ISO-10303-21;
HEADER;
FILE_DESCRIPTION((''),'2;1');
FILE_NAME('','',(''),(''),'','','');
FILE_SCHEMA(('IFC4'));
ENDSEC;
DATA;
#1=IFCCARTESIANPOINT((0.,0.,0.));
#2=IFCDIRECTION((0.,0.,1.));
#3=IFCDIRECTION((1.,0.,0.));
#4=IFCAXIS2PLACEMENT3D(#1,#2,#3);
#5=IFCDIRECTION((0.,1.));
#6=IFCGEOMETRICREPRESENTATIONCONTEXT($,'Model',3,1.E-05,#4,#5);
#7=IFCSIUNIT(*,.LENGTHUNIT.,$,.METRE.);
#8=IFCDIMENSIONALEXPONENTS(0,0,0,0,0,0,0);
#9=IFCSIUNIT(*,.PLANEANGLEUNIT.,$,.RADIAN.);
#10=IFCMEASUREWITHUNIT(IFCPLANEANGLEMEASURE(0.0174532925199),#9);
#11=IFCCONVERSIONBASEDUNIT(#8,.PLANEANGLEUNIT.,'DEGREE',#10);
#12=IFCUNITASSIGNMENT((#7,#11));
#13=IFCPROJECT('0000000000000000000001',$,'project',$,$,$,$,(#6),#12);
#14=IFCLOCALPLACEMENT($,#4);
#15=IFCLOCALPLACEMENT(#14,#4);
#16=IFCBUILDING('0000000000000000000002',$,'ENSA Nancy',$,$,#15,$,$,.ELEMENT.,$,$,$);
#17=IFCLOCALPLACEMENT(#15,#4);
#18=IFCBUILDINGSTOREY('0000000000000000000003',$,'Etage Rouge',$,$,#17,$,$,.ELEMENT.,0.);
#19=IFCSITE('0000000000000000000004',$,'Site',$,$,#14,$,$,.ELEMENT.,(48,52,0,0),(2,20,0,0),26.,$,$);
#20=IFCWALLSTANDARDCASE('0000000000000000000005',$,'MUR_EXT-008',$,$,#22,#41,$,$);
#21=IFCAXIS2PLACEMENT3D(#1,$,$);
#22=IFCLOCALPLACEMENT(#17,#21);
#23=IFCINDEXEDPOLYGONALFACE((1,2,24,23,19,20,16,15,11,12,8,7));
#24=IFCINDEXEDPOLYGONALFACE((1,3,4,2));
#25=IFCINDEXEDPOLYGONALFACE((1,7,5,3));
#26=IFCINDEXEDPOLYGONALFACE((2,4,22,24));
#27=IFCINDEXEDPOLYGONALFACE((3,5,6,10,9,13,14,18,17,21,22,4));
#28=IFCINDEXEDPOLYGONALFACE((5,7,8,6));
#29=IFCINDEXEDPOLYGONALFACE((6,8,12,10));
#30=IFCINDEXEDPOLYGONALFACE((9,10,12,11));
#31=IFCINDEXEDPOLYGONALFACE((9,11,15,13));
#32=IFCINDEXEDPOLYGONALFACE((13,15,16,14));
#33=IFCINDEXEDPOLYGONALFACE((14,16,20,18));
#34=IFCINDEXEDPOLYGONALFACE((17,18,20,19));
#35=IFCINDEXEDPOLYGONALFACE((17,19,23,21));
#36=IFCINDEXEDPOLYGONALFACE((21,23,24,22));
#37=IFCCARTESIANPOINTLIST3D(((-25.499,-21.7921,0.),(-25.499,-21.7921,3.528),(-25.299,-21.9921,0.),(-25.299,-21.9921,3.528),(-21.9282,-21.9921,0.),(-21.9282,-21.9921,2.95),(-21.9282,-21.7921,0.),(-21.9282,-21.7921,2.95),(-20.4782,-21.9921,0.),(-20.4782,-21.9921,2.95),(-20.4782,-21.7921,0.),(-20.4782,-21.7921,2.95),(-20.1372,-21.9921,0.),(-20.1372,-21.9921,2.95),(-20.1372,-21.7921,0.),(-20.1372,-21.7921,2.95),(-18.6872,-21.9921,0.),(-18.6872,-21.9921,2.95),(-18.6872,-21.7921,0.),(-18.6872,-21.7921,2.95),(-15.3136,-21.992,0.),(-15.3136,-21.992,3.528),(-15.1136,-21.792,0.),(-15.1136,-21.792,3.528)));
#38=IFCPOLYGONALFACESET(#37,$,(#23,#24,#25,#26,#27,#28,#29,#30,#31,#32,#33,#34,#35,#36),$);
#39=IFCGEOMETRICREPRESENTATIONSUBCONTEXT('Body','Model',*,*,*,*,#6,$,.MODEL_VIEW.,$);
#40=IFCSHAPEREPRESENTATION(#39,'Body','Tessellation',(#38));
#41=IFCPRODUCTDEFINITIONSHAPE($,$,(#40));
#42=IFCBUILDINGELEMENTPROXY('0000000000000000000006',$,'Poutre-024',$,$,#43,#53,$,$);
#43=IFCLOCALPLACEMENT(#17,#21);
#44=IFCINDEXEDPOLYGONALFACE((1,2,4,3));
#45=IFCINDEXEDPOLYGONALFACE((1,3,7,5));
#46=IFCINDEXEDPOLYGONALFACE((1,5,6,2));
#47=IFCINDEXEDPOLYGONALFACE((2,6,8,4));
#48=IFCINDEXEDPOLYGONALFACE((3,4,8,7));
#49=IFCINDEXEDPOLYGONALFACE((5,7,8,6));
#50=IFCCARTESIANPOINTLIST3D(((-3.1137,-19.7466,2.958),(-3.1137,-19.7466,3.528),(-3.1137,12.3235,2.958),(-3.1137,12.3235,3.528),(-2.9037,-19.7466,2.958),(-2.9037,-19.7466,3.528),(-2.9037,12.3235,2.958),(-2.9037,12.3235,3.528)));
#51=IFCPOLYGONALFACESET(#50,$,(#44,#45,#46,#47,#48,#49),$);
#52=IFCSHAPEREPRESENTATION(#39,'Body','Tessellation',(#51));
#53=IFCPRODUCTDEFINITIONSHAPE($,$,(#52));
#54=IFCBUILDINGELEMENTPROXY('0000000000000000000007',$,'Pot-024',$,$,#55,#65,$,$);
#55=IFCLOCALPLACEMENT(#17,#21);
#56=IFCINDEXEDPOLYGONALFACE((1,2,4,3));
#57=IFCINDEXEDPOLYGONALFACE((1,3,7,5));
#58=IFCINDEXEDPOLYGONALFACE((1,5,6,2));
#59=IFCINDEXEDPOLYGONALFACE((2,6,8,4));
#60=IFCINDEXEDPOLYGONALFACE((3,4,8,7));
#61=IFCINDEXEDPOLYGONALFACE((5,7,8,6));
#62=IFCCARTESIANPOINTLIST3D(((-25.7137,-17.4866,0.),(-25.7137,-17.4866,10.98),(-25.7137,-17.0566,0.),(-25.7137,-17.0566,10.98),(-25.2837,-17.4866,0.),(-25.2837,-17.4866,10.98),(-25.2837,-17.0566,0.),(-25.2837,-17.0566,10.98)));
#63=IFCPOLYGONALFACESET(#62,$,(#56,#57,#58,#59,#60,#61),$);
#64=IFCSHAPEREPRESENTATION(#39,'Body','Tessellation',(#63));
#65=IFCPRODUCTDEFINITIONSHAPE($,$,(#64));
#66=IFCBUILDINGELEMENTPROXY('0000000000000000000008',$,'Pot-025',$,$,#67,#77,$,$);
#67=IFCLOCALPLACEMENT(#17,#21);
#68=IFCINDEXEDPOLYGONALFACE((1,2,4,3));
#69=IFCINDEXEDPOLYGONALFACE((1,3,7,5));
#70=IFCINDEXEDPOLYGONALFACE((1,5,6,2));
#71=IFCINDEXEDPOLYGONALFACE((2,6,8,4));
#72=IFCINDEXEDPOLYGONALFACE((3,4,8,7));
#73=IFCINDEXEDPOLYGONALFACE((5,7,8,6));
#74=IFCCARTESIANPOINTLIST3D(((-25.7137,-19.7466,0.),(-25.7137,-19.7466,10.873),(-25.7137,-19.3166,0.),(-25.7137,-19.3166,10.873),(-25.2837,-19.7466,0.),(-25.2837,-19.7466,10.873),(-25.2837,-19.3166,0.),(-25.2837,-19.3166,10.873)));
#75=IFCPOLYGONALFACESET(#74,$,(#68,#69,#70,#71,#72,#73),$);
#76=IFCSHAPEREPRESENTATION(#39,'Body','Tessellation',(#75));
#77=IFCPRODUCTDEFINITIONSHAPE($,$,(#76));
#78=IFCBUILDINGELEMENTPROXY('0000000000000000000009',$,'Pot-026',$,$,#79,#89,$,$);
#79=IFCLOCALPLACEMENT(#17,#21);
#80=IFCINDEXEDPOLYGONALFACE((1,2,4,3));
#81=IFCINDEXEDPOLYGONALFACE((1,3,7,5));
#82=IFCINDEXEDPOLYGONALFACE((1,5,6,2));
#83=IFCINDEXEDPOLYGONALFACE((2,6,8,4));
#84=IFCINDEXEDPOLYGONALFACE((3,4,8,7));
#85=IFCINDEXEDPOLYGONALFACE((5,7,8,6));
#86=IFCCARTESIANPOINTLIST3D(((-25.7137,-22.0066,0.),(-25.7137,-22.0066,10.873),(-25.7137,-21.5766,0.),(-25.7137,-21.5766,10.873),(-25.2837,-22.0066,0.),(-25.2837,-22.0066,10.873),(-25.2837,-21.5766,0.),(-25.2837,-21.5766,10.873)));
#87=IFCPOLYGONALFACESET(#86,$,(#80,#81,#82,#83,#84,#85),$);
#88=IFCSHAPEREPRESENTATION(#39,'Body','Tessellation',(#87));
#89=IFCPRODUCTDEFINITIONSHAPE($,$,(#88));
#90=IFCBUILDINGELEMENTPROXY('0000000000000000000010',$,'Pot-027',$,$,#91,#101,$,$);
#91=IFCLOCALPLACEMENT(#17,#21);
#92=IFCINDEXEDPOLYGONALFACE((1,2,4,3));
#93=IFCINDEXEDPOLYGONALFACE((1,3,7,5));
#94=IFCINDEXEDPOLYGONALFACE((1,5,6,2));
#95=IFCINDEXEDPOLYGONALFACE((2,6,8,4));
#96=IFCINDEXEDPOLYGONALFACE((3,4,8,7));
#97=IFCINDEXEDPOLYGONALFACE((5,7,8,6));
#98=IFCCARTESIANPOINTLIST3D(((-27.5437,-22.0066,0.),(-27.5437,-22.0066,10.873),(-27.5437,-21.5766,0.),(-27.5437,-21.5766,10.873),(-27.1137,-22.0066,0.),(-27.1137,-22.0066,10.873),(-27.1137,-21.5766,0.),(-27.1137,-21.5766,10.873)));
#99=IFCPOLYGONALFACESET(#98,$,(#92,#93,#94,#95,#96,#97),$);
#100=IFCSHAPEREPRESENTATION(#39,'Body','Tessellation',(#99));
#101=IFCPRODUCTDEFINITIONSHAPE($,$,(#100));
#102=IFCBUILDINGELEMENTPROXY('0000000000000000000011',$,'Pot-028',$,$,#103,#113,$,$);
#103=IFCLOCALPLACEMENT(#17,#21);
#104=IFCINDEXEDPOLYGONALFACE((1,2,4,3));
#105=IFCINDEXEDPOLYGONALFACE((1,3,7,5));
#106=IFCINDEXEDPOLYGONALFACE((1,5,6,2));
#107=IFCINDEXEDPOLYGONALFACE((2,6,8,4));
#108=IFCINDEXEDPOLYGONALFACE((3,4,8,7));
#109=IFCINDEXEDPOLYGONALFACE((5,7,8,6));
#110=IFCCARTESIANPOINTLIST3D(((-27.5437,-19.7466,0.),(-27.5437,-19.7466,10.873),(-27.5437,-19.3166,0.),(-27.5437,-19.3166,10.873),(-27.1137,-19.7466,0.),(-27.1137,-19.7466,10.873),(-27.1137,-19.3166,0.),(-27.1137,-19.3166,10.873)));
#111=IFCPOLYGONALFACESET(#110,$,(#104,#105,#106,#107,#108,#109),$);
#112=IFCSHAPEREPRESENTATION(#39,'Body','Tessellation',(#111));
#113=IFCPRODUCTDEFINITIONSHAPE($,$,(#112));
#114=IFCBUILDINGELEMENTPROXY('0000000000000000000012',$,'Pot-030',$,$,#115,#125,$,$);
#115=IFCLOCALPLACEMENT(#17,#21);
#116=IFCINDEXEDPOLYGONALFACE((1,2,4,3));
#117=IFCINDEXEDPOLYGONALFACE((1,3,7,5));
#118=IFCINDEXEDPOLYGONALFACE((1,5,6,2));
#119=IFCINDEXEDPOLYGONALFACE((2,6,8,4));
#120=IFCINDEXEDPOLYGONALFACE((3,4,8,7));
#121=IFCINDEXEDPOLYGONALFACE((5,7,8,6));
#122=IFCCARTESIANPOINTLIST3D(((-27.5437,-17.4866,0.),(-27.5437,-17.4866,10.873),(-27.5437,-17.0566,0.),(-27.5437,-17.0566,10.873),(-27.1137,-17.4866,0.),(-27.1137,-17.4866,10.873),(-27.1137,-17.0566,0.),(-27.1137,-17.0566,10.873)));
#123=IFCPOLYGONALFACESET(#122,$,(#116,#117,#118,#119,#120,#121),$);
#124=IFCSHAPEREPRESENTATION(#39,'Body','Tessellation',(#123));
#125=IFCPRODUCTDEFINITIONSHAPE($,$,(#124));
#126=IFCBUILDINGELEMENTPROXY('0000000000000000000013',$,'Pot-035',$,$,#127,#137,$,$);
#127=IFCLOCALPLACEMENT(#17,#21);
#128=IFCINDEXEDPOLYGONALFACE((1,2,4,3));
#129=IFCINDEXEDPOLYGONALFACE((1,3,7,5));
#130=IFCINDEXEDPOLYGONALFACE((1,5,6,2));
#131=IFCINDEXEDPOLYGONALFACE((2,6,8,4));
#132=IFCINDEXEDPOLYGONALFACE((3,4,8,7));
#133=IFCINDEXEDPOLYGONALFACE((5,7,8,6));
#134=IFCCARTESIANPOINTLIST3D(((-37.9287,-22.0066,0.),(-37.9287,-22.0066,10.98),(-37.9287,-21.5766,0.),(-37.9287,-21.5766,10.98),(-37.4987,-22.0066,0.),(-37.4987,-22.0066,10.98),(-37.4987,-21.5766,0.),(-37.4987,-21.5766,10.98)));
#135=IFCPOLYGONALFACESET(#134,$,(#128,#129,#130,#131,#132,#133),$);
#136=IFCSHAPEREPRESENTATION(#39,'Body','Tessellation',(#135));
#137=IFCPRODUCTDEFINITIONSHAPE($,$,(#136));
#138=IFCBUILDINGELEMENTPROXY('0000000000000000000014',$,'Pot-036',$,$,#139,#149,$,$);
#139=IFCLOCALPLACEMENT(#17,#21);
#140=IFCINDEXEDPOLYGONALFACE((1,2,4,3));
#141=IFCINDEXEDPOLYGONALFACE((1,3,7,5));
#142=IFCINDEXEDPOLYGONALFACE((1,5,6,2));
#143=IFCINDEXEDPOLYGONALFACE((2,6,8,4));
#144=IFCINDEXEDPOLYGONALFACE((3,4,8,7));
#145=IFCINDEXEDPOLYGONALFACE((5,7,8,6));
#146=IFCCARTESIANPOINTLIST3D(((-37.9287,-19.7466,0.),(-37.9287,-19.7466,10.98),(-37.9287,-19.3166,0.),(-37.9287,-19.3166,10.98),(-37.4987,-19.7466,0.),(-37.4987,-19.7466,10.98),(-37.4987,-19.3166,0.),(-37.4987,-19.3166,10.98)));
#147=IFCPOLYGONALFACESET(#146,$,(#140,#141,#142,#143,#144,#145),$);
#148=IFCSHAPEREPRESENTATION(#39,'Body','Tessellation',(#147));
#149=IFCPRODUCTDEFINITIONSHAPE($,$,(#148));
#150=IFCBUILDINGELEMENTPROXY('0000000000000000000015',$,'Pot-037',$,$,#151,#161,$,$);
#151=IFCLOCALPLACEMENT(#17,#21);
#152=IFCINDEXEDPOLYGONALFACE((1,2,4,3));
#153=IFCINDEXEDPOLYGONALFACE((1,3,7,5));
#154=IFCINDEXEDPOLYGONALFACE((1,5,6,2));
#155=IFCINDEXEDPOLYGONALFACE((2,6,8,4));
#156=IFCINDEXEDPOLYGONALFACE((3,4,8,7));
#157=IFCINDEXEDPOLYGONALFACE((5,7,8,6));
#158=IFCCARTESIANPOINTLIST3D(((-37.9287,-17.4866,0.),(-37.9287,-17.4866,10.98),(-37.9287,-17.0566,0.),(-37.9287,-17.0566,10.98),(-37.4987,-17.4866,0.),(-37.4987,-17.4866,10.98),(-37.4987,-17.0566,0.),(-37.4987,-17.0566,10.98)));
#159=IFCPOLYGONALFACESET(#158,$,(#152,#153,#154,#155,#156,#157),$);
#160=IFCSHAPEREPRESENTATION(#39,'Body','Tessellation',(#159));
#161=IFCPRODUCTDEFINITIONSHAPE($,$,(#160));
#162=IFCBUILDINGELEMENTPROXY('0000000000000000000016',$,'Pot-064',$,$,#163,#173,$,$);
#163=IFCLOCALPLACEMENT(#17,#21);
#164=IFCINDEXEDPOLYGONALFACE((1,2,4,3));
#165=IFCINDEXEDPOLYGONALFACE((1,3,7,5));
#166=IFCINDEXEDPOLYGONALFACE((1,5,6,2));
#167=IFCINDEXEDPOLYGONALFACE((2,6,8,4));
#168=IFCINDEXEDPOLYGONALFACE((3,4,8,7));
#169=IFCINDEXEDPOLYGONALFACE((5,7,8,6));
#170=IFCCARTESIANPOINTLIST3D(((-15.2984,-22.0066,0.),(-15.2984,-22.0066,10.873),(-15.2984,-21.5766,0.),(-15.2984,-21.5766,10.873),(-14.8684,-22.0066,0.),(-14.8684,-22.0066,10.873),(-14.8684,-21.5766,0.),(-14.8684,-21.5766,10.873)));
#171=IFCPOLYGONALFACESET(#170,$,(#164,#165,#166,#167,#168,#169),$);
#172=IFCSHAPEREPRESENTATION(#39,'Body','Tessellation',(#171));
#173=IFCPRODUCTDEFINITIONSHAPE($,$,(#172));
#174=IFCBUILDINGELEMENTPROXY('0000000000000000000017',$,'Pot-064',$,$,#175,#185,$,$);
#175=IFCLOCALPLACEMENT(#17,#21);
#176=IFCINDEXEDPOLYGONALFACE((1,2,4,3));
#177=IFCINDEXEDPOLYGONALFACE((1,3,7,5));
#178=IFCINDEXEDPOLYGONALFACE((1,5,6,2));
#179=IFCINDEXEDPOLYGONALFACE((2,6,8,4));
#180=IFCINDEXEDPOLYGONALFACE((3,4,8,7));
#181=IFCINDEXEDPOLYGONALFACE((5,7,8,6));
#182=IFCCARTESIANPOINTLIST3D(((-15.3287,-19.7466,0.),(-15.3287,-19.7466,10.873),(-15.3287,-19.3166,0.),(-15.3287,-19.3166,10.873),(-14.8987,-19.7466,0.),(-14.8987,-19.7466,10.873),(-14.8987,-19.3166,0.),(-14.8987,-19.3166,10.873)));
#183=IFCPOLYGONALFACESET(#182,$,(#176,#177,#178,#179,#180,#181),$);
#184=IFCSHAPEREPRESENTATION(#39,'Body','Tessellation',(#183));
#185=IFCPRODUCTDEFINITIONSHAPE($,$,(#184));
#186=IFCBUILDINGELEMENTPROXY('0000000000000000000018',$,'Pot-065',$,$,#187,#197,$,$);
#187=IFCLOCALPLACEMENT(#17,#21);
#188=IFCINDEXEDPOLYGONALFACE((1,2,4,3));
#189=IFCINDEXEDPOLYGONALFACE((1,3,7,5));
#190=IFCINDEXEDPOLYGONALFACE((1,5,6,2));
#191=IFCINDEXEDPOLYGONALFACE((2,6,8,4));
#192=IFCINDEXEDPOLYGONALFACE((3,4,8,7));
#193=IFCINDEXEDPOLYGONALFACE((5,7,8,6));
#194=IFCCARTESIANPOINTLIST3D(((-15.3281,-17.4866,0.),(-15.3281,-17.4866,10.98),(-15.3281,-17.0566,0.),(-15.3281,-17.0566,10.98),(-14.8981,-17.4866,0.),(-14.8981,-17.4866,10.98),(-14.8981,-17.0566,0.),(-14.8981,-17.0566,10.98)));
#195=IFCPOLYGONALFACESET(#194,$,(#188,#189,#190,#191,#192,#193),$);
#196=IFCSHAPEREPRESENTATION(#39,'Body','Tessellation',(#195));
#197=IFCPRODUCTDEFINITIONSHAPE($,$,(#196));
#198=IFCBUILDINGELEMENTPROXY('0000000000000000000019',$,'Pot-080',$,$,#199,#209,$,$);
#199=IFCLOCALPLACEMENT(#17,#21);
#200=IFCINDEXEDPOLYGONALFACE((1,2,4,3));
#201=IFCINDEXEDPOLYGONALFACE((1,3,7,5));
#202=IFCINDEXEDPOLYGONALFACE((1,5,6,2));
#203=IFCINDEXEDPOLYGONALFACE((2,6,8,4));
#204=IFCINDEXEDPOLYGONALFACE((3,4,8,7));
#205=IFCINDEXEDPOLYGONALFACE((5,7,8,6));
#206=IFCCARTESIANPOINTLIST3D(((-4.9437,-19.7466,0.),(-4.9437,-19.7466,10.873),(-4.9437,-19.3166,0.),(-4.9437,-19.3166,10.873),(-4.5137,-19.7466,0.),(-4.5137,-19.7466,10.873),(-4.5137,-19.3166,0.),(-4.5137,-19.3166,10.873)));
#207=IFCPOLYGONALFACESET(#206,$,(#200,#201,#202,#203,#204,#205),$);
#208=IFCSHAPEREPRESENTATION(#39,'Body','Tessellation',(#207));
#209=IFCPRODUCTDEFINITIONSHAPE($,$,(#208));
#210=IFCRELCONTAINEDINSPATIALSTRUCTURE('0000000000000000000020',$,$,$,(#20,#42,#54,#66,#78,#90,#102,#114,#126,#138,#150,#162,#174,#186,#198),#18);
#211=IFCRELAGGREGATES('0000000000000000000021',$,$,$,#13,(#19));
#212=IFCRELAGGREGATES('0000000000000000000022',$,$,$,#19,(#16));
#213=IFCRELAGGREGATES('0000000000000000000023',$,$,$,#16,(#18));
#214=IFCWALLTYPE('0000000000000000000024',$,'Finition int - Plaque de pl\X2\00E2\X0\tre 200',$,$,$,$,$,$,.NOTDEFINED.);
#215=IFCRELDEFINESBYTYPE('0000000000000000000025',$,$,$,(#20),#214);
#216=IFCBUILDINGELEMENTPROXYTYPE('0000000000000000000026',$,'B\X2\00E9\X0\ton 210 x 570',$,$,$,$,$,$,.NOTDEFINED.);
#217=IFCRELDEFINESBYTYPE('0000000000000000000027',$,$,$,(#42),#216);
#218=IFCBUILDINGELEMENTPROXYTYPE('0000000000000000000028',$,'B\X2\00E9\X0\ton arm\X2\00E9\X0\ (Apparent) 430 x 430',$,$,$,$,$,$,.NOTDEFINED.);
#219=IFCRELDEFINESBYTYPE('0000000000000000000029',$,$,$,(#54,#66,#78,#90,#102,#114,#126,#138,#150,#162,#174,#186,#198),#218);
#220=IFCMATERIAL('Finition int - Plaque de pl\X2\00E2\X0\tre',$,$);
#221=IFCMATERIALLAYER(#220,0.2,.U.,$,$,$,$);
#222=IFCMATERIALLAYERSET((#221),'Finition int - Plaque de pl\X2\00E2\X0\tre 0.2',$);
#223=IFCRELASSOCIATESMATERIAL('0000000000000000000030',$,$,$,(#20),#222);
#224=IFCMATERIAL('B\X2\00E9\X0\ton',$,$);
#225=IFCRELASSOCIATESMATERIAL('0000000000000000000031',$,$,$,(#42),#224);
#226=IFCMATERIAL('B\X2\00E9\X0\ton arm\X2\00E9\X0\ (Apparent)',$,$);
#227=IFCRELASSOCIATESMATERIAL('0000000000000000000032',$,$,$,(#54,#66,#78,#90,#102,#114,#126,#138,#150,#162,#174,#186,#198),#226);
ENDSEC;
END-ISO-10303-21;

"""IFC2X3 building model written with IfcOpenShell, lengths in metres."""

from ifc_helpers import new_model, entity, si_unit, converted_unit, direction, frame, frame_2d, origin_with_axes, origin_2d_with_axis, place, context, subcontext, project, spatial, polyline, rectangle, outline, extrude, material, layer, layer_set, layer_usage, type_object, element, save


model = new_model("IFC2X3")

# Units and contexts
model_context = context("Model", 3, precision=1e-05, world=origin_with_axes(), true_north=direction((0.0, 1.0)))
body_context = subcontext(model_context, "Body", "Model", "MODEL_VIEW")
ifc_project = project(units=[si_unit("LENGTHUNIT", "METRE"), converted_unit("PLANEANGLEUNIT", "DEGREE", entity("IfcPlaneAngleMeasure", 0.0174532925199), si_unit("PLANEANGLEUNIT", "RADIAN"), dimensions=[0, 0, 0, 0, 0, 0, 0])], contexts=[model_context])

# Site, building, storey
site_placement = place(None, origin_with_axes())
site = spatial("IfcSite", under=ifc_project, at=site_placement, Name="Site", CompositionType="ELEMENT", RefLatitude=(48, 52, 0, 0), RefLongitude=(2, 20, 0, 0), RefElevation=26.0)
building_placement = place(site_placement, origin_with_axes())
building = spatial("IfcBuilding", under=site, at=building_placement, Name="ENSA Nancy", CompositionType="ELEMENT")
storey_placement = place(building_placement, origin_with_axes())
storey = spatial("IfcBuildingStorey", under=building, at=storey_placement, Name="Etage Rouge", CompositionType="ELEMENT", Elevation=0.0)

# Wall, openings
ifc_material_1 = material(Name="Finition int - Plaque de plâtre")
ifc_layer = layer(ifc_material_1, 0.2, ventilated="UNKNOWN")
ifc_layer_set = layer_set([ifc_layer], Name="Finition int - Plaque de plâtre 0.2")
ifc_layer_usage = layer_usage(ifc_layer_set, "AXIS2", "POSITIVE", 0.0)
wall_type = type_object("IfcWallType", Name="Finition int - Plaque de plâtre 200", PredefinedType="NOTDEFINED")
wall_placement = place(storey_placement, frame((-15.1136, -21.792, 0.0), z_axis=(0.0, 0.0, 1.0), x_axis=(-1.0, -0.000003, 0.0)))
wall = element("IfcWallStandardCase", 1, at=wall_placement, inside=storey, type_object=wall_type, material=ifc_layer_usage, Name="MUR_EXT-008", context=body_context, shape_type="SweptSolid", body=[
    extrude(outline(polyline([(0.0, 0.0), (10.3854, 0.0), (10.1854, 0.2), (0.2, 0.2), (0.0, 0.0)])), origin_with_axes(), (0.0, 0.0, 1.0), 3.528),
])
opening_1_placement = place(wall_placement, frame((6.0896, 0.0, 0.0), z_axis=(0.0, 0.0, 1.0), x_axis=(1.0, 0.0, 0.0)))
element("IfcOpeningElement", 2, at=opening_1_placement, cuts=wall, context=body_context, shape_type="SweptSolid", body=[
    extrude(rectangle(XDim=1.45, YDim=2.95, at=origin_2d_with_axis()), frame((0.0, 0.2, 1.475), z_axis=(0.0, 1.0, 0.0), x_axis=(1.0, 0.0, 0.0)), (0.0, 0.0, -1.0), 0.6),
])
opening_2_placement = place(wall_placement, frame((4.2986, 0.0, 0.0), z_axis=(0.0, 0.0, 1.0), x_axis=(1.0, 0.0, 0.0)))
element("IfcOpeningElement", 3, at=opening_2_placement, cuts=wall, context=body_context, shape_type="SweptSolid", body=[
    extrude(rectangle(XDim=1.45, YDim=2.95, at=origin_2d_with_axis()), frame((0.0, 0.2, 1.475), z_axis=(0.0, -1.0, 0.0), x_axis=(-1.0, 0.0, 0.0)), (0.0, 0.0, 1.0), 0.6),
])

# Building element proxies
ifc_material_2 = material(Name="Béton")
building_element_proxy_type_1 = type_object("IfcBuildingElementProxyType", Name="Béton 210 x 570", PredefinedType="NOTDEFINED")
proxy_1_placement = place(storey_placement, frame((-3.0087, -19.7466, 3.528), z_axis=(0.0, 0.0, 1.0), x_axis=(1.0, 0.0, 0.0)))
element("IfcBuildingElementProxy", 4, at=proxy_1_placement, inside=storey, type_object=building_element_proxy_type_1, material=ifc_material_2, Name="Poutre-024", context=body_context, shape_type="SweptSolid", body=[
    extrude(rectangle(XDim=0.57, YDim=0.21, at=frame_2d((-0.285, 0.0), x_axis=(1.0, 0.0))), frame((0.0, 0.0, 0.0), z_axis=(0.0, 1.0, 0.0), x_axis=(0.0, 0.0, 1.0)), (0.0, 0.0, 1.0), 32.07),
])
ifc_material_3 = material(Name="Béton armé (Apparent)")
building_element_proxy_type_2 = type_object("IfcBuildingElementProxyType", Name="Béton armé (Apparent) 430 x 430", PredefinedType="NOTDEFINED")
proxy_2_placement = place(storey_placement, frame((-25.4987, -17.2716, 0.0), z_axis=(0.0, 0.0, 1.0), x_axis=(1.0, 0.0, 0.0)))
element("IfcBuildingElementProxy", 5, at=proxy_2_placement, inside=storey, type_object=building_element_proxy_type_2, material=ifc_material_3, Name="Pot-024", context=body_context, shape_type="SweptSolid", body=[
    extrude(rectangle(XDim=0.43, YDim=0.43, at=origin_2d_with_axis()), origin_with_axes(), (0.0, 0.0, 1.0), 10.98),
])
for number, where, z_axis, x_axis, name in (
    (6, (-25.4987, -19.5316, 0.0), (0.0, 0.0, 1.0), (1.0, 0.0, 0.0), "Pot-025"),
    (7, (-25.4987, -21.7916, 0.0), (0.0, 0.0, 1.0), (1.0, 0.0, 0.0), "Pot-026"),
    (8, (-27.3287, -21.7916, 0.0), (0.0, 0.0, 1.0), (1.0, 0.0, 0.0), "Pot-027"),
    (9, (-27.3287, -19.5316, 0.0), (0.0, 0.0, 1.0), (1.0, 0.0, 0.0), "Pot-028"),
    (10, (-27.3287, -17.2716, 0.0), (0.0, 0.0, 1.0), (1.0, 0.0, 0.0), "Pot-030"),
):
    element("IfcBuildingElementProxy", number, at=place(storey_placement, frame(where, z_axis=z_axis, x_axis=x_axis)), inside=storey, type_object=building_element_proxy_type_2, material=ifc_material_3, Name=name, context=body_context, shape_type="SweptSolid", body=[
        extrude(rectangle(XDim=0.43, YDim=0.43, at=origin_2d_with_axis()), origin_with_axes(), (0.0, 0.0, 1.0), 10.873),
    ])
for number, where, z_axis, x_axis, name in (
    (11, (-37.7137, -21.7916, 0.0), (0.0, 0.0, 1.0), (1.0, 0.0, 0.0), "Pot-035"),
    (12, (-37.7137, -19.5316, 0.0), (0.0, 0.0, 1.0), (1.0, 0.0, 0.0), "Pot-036"),
    (13, (-37.7137, -17.2716, 0.0), (0.0, 0.0, 1.0), (1.0, 0.0, 0.0), "Pot-037"),
):
    element("IfcBuildingElementProxy", number, at=place(storey_placement, frame(where, z_axis=z_axis, x_axis=x_axis)), inside=storey, type_object=building_element_proxy_type_2, material=ifc_material_3, Name=name, context=body_context, shape_type="SweptSolid", body=[
        extrude(rectangle(XDim=0.43, YDim=0.43, at=origin_2d_with_axis()), origin_with_axes(), (0.0, 0.0, 1.0), 10.98),
    ])
for number, where, z_axis, x_axis, name in (
    (14, (-15.0834, -21.7916, 0.0), (0.0, 0.0, 1.0), (1.0, 0.0, 0.0), "Pot-064"),
    (15, (-15.1137, -19.5316, 0.0), (0.0, 0.0, 1.0), (1.0, 0.0, 0.0), "Pot-064"),
):
    element("IfcBuildingElementProxy", number, at=place(storey_placement, frame(where, z_axis=z_axis, x_axis=x_axis)), inside=storey, type_object=building_element_proxy_type_2, material=ifc_material_3, Name=name, context=body_context, shape_type="SweptSolid", body=[
        extrude(rectangle(XDim=0.43, YDim=0.43, at=origin_2d_with_axis()), origin_with_axes(), (0.0, 0.0, 1.0), 10.873),
    ])
proxy_3_placement = place(storey_placement, frame((-15.1131, -17.2716, 0.0), z_axis=(0.0, 0.0, 1.0), x_axis=(1.0, 0.0, 0.0)))
element("IfcBuildingElementProxy", 16, at=proxy_3_placement, inside=storey, type_object=building_element_proxy_type_2, material=ifc_material_3, Name="Pot-065", context=body_context, shape_type="SweptSolid", body=[
    extrude(rectangle(XDim=0.43, YDim=0.43, at=origin_2d_with_axis()), origin_with_axes(), (0.0, 0.0, 1.0), 10.98),
])
for number, where, z_axis, x_axis, name in (
    (17, (-4.7287, -19.5316, 0.0), (0.0, 0.0, 1.0), (1.0, 0.0, 0.0), "Pot-080"),
):
    element("IfcBuildingElementProxy", number, at=place(storey_placement, frame(where, z_axis=z_axis, x_axis=x_axis)), inside=storey, type_object=building_element_proxy_type_2, material=ifc_material_3, Name=name, context=body_context, shape_type="SweptSolid", body=[
        extrude(rectangle(XDim=0.43, YDim=0.43, at=origin_2d_with_axis()), origin_with_axes(), (0.0, 0.0, 1.0), 10.873),
    ])

save(model, "model.ifc")
